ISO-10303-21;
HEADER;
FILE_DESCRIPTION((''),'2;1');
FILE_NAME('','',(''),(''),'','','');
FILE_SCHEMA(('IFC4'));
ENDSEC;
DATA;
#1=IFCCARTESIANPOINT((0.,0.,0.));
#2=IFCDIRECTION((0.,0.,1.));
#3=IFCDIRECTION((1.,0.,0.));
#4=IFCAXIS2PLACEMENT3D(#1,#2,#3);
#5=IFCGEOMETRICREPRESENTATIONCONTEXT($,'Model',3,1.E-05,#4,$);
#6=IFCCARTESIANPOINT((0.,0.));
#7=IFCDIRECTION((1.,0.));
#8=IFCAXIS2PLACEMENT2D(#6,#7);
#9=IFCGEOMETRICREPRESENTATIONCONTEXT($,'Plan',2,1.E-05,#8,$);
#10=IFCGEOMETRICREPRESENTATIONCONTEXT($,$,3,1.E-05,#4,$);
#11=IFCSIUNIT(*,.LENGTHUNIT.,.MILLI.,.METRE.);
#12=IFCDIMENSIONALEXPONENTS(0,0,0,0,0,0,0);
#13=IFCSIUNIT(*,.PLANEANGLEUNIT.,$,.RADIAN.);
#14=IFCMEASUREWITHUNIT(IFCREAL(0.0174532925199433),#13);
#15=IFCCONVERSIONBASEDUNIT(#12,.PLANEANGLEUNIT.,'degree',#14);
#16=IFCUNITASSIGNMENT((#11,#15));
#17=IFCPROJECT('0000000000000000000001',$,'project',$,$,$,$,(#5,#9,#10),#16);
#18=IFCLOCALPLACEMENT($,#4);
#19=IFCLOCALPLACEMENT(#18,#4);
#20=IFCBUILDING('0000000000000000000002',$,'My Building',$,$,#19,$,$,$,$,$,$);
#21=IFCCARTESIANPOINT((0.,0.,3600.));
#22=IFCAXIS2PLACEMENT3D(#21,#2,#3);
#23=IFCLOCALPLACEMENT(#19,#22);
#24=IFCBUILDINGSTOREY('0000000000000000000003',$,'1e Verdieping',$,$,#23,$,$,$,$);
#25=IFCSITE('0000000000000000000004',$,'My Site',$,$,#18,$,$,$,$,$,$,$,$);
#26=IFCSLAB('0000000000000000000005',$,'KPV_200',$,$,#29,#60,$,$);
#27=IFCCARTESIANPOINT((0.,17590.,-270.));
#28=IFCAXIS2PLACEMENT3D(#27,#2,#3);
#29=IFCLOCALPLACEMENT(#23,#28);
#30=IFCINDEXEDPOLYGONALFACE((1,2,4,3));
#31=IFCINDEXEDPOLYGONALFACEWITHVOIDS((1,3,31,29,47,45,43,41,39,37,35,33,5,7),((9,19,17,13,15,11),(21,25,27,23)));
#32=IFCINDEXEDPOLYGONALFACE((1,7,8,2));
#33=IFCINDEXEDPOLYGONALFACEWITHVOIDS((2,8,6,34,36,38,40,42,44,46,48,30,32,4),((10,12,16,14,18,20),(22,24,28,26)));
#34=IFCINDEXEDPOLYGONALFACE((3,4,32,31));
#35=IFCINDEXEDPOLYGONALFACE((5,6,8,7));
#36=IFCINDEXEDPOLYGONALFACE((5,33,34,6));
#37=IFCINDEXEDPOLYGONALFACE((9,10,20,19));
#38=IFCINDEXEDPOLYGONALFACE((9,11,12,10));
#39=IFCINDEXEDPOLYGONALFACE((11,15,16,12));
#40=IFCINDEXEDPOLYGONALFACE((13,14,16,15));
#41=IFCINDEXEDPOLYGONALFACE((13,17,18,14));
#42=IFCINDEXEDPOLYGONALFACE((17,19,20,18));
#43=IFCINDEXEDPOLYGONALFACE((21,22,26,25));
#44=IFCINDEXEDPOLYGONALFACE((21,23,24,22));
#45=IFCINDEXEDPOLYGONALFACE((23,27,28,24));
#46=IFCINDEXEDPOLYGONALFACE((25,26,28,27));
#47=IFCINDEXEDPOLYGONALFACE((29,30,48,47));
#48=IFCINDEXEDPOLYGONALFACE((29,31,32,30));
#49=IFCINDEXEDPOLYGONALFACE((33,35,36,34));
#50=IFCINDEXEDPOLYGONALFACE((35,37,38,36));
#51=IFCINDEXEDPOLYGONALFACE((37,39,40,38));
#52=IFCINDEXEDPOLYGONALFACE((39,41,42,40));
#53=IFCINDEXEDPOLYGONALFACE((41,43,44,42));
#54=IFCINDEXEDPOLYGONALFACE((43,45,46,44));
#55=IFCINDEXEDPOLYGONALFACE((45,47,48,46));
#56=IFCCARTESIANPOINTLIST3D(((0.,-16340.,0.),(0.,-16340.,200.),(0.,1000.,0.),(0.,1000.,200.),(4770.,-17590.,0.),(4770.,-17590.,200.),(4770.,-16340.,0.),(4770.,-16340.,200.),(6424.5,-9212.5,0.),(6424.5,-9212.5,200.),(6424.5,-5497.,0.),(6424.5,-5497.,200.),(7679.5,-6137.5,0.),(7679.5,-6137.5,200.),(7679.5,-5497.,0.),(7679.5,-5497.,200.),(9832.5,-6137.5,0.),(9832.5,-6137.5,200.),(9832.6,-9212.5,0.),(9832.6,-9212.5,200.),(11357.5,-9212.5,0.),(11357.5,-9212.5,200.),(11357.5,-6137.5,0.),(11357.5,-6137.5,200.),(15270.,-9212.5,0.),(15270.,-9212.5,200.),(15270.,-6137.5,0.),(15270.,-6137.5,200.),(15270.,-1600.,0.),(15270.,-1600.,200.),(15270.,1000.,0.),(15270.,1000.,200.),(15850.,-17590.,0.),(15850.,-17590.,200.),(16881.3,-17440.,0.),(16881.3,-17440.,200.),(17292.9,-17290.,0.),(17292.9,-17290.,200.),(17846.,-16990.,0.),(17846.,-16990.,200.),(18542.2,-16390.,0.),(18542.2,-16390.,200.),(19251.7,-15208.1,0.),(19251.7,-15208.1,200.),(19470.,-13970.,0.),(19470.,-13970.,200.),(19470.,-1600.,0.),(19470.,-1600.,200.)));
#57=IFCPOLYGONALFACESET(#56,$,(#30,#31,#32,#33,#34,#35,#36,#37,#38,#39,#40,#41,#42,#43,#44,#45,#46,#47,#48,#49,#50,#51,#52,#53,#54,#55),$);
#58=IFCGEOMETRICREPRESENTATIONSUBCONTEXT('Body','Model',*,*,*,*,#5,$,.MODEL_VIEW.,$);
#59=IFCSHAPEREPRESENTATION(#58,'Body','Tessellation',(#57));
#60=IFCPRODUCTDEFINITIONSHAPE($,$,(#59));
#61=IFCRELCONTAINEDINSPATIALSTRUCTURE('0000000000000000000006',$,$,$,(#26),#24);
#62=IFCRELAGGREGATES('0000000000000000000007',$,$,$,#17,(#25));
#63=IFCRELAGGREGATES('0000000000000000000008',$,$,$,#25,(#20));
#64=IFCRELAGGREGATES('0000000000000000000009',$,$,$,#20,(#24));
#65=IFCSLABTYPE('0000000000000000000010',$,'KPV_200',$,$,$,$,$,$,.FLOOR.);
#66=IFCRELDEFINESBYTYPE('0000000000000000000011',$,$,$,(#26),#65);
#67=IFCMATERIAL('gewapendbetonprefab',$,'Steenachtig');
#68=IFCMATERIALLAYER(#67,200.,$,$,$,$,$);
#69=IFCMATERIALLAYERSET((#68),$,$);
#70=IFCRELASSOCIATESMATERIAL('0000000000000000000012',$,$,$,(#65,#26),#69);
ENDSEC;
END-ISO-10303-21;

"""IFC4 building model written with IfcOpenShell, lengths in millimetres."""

from ifc_helpers import new_model, entity, si_unit, converted_unit, frame, origin_with_axes, origin_2d_with_axis, place, context, subcontext, project, spatial, line, indexed_curve, outline, extrude, material, layer, layer_set, layer_usage, type_object, element, save


model = new_model("IFC4")

# Units and contexts
model_context = context("Model", 3, precision=1e-05, world=origin_with_axes())
plan_context = context("Plan", 2, precision=1e-05, world=origin_2d_with_axis())
context_of_model = context(None, 3, precision=1e-05, world=origin_with_axes())
body_context = subcontext(model_context, "Body", "Model", "MODEL_VIEW")
ifc_project = project(units=[si_unit("LENGTHUNIT", "METRE", prefix="MILLI"), converted_unit("PLANEANGLEUNIT", "degree", entity("IfcReal", 0.0174532925199433), si_unit("PLANEANGLEUNIT", "RADIAN"), dimensions=[0, 0, 0, 0, 0, 0, 0])], contexts=[model_context, plan_context, context_of_model])

# Site, building, storey
site_placement = place(None, origin_with_axes())
site = spatial("IfcSite", under=ifc_project, at=site_placement, Name="My Site")
building_placement = place(site_placement, origin_with_axes())
building = spatial("IfcBuilding", under=site, at=building_placement, Name="My Building")
storey_placement = place(building_placement, frame((0.0, 0.0, 3600.0), z_axis=(0.0, 0.0, 1.0), x_axis=(1.0, 0.0, 0.0)))
storey = spatial("IfcBuildingStorey", under=building, at=storey_placement, Name="1e Verdieping")

# Slab
ifc_material_1 = material(Name="gewapendbetonprefab", Category="Steenachtig")
ifc_layer = layer(ifc_material_1, 200.0)
ifc_layer_set = layer_set([ifc_layer])
ifc_layer_usage = layer_usage(ifc_layer_set, "AXIS3", "POSITIVE", 0.0)
slab_type = type_object("IfcSlabType", Name="KPV_200", PredefinedType="FLOOR", material=ifc_layer_set)
slab_placement = place(storey_placement, frame((0.0, 17590.0, -270.0), z_axis=(0.0, 0.0, 1.0), x_axis=(1.0, 0.0, 0.0)))
element("IfcSlab", 1, at=slab_placement, inside=storey, type_object=slab_type, material=ifc_layer_usage, Name="KPV_200", context=body_context, shape_type="SweptSolid", body=[
    extrude(outline(indexed_curve([(17846.0, -16990.0), (17292.9, -17290.0), (16881.3, -17440.0), (15850.0, -17590.0), (4770.0, -17590.0), (4770.0, -16340.0), (0.0, -16340.0), (0.0, 1000.0), (15270.0, 1000.0), (15270.0, -1600.0), (19470.0, -1600.0), (19470.0, -13970.0), (19251.7, -15208.1), (18542.2, -16390.0), (15270.0, -9212.5), (15270.0, -6137.5), (11357.5, -9212.5), (11357.5, -6137.5), (9832.5, -6137.5), (7679.5, -6137.5), (7679.5, -5497.0), (6424.5, -5497.0), (6424.5, -9212.5), (9832.6, -9212.5)], segments=[line(13, 14), line(14, 1), line(1, 2), line(2, 3), line(3, 4), line(4, 5), line(5, 6), line(6, 7), line(7, 8), line(8, 9), line(9, 10), line(10, 11), line(11, 12), line(12, 13)], self_intersect=False), holes=[indexed_curve([(17846.0, -16990.0), (17292.9, -17290.0), (16881.3, -17440.0), (15850.0, -17590.0), (4770.0, -17590.0), (4770.0, -16340.0), (0.0, -16340.0), (0.0, 1000.0), (15270.0, 1000.0), (15270.0, -1600.0), (19470.0, -1600.0), (19470.0, -13970.0), (19251.7, -15208.1), (18542.2, -16390.0), (15270.0, -9212.5), (15270.0, -6137.5), (11357.5, -9212.5), (11357.5, -6137.5), (9832.5, -6137.5), (7679.5, -6137.5), (7679.5, -5497.0), (6424.5, -5497.0), (6424.5, -9212.5), (9832.6, -9212.5)], segments=[line(23, 22), line(22, 21), line(21, 20), line(20, 19), line(19, 24), line(24, 23)], self_intersect=False), indexed_curve([(17846.0, -16990.0), (17292.9, -17290.0), (16881.3, -17440.0), (15850.0, -17590.0), (4770.0, -17590.0), (4770.0, -16340.0), (0.0, -16340.0), (0.0, 1000.0), (15270.0, 1000.0), (15270.0, -1600.0), (19470.0, -1600.0), (19470.0, -13970.0), (19251.7, -15208.1), (18542.2, -16390.0), (15270.0, -9212.5), (15270.0, -6137.5), (11357.5, -9212.5), (11357.5, -6137.5), (9832.5, -6137.5), (7679.5, -6137.5), (7679.5, -5497.0), (6424.5, -5497.0), (6424.5, -9212.5), (9832.6, -9212.5)], segments=[line(18, 17), line(17, 15), line(15, 16), line(16, 18)], self_intersect=False)]), None, (0.0, 0.0, 1.0), 200.0),
])

save(model, "model.ifc")
